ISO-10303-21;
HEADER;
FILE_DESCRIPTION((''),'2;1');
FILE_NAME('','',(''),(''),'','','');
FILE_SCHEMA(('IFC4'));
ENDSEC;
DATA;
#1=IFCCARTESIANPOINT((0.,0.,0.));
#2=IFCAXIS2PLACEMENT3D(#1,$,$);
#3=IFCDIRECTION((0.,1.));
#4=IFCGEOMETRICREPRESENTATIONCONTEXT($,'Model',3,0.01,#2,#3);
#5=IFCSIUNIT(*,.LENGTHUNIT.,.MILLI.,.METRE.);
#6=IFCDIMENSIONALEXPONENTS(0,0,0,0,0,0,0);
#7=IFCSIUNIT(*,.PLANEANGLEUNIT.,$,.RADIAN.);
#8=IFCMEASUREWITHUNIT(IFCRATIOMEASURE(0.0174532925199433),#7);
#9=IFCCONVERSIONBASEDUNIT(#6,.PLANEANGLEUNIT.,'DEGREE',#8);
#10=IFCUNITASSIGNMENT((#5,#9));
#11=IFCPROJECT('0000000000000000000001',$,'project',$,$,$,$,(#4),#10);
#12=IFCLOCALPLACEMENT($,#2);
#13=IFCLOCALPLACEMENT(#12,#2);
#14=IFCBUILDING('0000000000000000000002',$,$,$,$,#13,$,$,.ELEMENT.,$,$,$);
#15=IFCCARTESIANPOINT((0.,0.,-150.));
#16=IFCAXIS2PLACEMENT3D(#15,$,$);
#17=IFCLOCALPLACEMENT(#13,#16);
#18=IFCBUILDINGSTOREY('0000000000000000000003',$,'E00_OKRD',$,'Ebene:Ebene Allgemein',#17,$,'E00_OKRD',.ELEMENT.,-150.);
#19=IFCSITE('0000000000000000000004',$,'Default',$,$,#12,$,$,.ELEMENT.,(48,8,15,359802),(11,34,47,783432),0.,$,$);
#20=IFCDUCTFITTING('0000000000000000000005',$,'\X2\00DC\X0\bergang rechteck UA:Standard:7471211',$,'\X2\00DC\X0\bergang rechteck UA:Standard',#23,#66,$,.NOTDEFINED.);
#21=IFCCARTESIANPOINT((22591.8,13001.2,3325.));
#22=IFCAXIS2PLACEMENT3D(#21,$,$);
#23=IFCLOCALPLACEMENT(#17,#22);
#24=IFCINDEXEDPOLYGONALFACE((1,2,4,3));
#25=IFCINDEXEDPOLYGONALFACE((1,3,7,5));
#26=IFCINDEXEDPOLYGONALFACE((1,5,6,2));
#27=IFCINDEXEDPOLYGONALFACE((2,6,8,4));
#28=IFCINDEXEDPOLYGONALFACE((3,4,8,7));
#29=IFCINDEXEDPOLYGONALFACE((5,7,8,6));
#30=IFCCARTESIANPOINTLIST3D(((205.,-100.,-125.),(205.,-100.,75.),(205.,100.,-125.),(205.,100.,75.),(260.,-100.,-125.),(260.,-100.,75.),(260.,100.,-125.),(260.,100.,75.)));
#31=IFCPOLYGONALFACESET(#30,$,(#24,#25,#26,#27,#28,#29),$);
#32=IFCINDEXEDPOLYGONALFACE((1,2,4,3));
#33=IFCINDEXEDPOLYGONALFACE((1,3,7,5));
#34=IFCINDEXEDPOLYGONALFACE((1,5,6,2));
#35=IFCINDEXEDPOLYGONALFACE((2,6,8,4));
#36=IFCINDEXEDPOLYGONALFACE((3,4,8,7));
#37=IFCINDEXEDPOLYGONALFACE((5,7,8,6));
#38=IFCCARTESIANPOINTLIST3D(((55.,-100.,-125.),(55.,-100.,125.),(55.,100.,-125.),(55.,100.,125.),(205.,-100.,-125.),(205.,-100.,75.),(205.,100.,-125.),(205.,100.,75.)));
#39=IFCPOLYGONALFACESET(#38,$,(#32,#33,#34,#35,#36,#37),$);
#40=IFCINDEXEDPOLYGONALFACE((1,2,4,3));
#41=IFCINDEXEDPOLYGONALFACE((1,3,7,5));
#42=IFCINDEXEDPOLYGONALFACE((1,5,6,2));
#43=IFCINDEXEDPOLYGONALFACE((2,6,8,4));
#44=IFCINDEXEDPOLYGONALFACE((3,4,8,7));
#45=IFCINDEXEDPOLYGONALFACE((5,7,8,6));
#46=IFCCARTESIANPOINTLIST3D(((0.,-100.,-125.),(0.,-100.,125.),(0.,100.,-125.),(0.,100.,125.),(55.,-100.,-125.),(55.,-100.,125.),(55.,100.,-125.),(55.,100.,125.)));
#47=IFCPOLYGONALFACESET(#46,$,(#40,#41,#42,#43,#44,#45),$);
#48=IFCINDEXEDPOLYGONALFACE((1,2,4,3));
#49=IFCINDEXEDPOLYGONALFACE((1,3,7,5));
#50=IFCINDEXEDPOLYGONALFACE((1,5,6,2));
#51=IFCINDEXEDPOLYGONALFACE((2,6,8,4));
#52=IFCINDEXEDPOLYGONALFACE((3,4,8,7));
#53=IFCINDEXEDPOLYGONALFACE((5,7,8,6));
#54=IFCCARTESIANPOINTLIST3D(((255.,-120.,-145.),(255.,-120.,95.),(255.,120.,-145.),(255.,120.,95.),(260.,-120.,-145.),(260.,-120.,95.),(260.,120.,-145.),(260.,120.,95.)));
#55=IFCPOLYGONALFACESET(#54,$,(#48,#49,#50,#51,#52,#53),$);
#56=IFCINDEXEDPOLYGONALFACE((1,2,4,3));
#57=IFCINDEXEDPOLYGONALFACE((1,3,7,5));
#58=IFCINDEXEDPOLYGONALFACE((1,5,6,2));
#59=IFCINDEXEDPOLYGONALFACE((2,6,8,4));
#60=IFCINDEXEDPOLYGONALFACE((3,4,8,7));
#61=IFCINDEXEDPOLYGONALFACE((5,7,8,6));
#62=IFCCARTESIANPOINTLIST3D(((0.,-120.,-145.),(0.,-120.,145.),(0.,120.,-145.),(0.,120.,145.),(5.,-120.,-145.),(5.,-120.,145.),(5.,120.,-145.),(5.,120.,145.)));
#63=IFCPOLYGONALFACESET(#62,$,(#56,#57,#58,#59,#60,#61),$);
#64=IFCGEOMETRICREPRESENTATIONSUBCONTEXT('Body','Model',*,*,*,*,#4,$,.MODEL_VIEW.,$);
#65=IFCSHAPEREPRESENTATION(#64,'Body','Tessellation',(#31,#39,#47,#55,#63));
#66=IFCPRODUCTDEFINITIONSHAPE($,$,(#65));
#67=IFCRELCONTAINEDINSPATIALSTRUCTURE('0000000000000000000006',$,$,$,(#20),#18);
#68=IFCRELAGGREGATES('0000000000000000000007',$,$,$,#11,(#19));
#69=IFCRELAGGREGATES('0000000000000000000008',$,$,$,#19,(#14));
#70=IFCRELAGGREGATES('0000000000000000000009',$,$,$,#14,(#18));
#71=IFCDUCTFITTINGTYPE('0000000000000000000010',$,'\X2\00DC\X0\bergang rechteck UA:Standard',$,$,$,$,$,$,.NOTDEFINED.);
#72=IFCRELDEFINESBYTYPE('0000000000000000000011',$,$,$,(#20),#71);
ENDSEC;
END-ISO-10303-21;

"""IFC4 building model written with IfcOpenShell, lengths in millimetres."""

from ifc_helpers import new_model, entity, si_unit, converted_unit, direction, frame, frame_2d, origin, place, context, subcontext, project, spatial, polyline, rectangle, outline, extrude, source, transform, mapped, type_object, type_shapes, element, save


model = new_model("IFC4")

# Units and contexts
model_context = context("Model", 3, precision=0.01, world=origin(), true_north=direction((0.0, 1.0)))
body_context = subcontext(model_context, "Body", "Model", "MODEL_VIEW")
ifc_project = project(units=[si_unit("LENGTHUNIT", "METRE", prefix="MILLI"), converted_unit("PLANEANGLEUNIT", "DEGREE", entity("IfcRatioMeasure", 0.0174532925199433), si_unit("PLANEANGLEUNIT", "RADIAN"), dimensions=[0, 0, 0, 0, 0, 0, 0])], contexts=[model_context])

# Site, building, storey
site_placement = place(None, origin())
site = spatial("IfcSite", under=ifc_project, at=site_placement, Name="Default", CompositionType="ELEMENT", RefLatitude=(48, 8, 15, 359802), RefLongitude=(11, 34, 47, 783432), RefElevation=0.0)
building_placement = place(site_placement, origin())
building = spatial("IfcBuilding", under=site, at=building_placement, CompositionType="ELEMENT")
storey_placement = place(building_placement, frame((0.0, 0.0, -150.0)))
storey = spatial("IfcBuildingStorey", under=building, at=storey_placement, Name="E00_OKRD", ObjectType="Ebene:Ebene Allgemein", LongName="E00_OKRD", CompositionType="ELEMENT", Elevation=-150.0)

# Duct fitting
duct_fitting_type_1 = type_object("IfcDuctFittingType", Name="Übergang rechteck UA:Standard", PredefinedType="NOTDEFINED")
shared_shape_1 = source(origin(), body_context, "Body", "SweptSolid", [
    extrude(rectangle(XDim=55.0, YDim=200.0, at=frame_2d((0.0, 0.0), x_axis=(1.0, 0.0))), frame((232.5, 0.0, -125.0)), (0.0, 0.0, 1.0), 200.0),
    extrude(outline(polyline([(-114.6, -106.7), (43.5, -106.7), (106.7, 83.0), (-35.6, 130.4), (-114.6, -106.7)])), frame((130.0, -100.0, -12.5), z_axis=(0.0, 1.0, 0.0), x_axis=(0.948683, 0.0, -0.316228)), (0.0, 0.0, 1.0), 200.0),
    extrude(rectangle(XDim=55.0, YDim=200.0, at=frame_2d((0.0, 0.0), x_axis=(1.0, 0.0))), frame((27.5, 0.0, -125.0)), (0.0, 0.0, 1.0), 250.0),
    extrude(rectangle(XDim=5.0, YDim=240.0, at=frame_2d((0.0, 0.0), x_axis=(1.0, 0.0))), frame((257.5, 0.0, -145.0)), (0.0, 0.0, 1.0), 240.0),
    extrude(rectangle(XDim=5.0, YDim=240.0, at=frame_2d((0.0, 0.0), x_axis=(1.0, 0.0))), frame((2.5, 0.0, -145.0)), (0.0, 0.0, 1.0), 290.0),
])
type_shapes(duct_fitting_type_1, [shared_shape_1])
duct_fitting_1_placement = place(storey_placement, frame((22591.8, 13001.2, 3325.0)))
element("IfcDuctFitting", 1, at=duct_fitting_1_placement, inside=storey, type_object=duct_fitting_type_1, Name="Übergang rechteck UA:Standard:7471211", ObjectType="Übergang rechteck UA:Standard", PredefinedType="NOTDEFINED", context=body_context, shape_type="MappedRepresentation", body=[
    mapped(shared_shape_1, transform((0.0, 0.0, 0.0), scale=1.0)),
])

save(model, "model.ifc")
